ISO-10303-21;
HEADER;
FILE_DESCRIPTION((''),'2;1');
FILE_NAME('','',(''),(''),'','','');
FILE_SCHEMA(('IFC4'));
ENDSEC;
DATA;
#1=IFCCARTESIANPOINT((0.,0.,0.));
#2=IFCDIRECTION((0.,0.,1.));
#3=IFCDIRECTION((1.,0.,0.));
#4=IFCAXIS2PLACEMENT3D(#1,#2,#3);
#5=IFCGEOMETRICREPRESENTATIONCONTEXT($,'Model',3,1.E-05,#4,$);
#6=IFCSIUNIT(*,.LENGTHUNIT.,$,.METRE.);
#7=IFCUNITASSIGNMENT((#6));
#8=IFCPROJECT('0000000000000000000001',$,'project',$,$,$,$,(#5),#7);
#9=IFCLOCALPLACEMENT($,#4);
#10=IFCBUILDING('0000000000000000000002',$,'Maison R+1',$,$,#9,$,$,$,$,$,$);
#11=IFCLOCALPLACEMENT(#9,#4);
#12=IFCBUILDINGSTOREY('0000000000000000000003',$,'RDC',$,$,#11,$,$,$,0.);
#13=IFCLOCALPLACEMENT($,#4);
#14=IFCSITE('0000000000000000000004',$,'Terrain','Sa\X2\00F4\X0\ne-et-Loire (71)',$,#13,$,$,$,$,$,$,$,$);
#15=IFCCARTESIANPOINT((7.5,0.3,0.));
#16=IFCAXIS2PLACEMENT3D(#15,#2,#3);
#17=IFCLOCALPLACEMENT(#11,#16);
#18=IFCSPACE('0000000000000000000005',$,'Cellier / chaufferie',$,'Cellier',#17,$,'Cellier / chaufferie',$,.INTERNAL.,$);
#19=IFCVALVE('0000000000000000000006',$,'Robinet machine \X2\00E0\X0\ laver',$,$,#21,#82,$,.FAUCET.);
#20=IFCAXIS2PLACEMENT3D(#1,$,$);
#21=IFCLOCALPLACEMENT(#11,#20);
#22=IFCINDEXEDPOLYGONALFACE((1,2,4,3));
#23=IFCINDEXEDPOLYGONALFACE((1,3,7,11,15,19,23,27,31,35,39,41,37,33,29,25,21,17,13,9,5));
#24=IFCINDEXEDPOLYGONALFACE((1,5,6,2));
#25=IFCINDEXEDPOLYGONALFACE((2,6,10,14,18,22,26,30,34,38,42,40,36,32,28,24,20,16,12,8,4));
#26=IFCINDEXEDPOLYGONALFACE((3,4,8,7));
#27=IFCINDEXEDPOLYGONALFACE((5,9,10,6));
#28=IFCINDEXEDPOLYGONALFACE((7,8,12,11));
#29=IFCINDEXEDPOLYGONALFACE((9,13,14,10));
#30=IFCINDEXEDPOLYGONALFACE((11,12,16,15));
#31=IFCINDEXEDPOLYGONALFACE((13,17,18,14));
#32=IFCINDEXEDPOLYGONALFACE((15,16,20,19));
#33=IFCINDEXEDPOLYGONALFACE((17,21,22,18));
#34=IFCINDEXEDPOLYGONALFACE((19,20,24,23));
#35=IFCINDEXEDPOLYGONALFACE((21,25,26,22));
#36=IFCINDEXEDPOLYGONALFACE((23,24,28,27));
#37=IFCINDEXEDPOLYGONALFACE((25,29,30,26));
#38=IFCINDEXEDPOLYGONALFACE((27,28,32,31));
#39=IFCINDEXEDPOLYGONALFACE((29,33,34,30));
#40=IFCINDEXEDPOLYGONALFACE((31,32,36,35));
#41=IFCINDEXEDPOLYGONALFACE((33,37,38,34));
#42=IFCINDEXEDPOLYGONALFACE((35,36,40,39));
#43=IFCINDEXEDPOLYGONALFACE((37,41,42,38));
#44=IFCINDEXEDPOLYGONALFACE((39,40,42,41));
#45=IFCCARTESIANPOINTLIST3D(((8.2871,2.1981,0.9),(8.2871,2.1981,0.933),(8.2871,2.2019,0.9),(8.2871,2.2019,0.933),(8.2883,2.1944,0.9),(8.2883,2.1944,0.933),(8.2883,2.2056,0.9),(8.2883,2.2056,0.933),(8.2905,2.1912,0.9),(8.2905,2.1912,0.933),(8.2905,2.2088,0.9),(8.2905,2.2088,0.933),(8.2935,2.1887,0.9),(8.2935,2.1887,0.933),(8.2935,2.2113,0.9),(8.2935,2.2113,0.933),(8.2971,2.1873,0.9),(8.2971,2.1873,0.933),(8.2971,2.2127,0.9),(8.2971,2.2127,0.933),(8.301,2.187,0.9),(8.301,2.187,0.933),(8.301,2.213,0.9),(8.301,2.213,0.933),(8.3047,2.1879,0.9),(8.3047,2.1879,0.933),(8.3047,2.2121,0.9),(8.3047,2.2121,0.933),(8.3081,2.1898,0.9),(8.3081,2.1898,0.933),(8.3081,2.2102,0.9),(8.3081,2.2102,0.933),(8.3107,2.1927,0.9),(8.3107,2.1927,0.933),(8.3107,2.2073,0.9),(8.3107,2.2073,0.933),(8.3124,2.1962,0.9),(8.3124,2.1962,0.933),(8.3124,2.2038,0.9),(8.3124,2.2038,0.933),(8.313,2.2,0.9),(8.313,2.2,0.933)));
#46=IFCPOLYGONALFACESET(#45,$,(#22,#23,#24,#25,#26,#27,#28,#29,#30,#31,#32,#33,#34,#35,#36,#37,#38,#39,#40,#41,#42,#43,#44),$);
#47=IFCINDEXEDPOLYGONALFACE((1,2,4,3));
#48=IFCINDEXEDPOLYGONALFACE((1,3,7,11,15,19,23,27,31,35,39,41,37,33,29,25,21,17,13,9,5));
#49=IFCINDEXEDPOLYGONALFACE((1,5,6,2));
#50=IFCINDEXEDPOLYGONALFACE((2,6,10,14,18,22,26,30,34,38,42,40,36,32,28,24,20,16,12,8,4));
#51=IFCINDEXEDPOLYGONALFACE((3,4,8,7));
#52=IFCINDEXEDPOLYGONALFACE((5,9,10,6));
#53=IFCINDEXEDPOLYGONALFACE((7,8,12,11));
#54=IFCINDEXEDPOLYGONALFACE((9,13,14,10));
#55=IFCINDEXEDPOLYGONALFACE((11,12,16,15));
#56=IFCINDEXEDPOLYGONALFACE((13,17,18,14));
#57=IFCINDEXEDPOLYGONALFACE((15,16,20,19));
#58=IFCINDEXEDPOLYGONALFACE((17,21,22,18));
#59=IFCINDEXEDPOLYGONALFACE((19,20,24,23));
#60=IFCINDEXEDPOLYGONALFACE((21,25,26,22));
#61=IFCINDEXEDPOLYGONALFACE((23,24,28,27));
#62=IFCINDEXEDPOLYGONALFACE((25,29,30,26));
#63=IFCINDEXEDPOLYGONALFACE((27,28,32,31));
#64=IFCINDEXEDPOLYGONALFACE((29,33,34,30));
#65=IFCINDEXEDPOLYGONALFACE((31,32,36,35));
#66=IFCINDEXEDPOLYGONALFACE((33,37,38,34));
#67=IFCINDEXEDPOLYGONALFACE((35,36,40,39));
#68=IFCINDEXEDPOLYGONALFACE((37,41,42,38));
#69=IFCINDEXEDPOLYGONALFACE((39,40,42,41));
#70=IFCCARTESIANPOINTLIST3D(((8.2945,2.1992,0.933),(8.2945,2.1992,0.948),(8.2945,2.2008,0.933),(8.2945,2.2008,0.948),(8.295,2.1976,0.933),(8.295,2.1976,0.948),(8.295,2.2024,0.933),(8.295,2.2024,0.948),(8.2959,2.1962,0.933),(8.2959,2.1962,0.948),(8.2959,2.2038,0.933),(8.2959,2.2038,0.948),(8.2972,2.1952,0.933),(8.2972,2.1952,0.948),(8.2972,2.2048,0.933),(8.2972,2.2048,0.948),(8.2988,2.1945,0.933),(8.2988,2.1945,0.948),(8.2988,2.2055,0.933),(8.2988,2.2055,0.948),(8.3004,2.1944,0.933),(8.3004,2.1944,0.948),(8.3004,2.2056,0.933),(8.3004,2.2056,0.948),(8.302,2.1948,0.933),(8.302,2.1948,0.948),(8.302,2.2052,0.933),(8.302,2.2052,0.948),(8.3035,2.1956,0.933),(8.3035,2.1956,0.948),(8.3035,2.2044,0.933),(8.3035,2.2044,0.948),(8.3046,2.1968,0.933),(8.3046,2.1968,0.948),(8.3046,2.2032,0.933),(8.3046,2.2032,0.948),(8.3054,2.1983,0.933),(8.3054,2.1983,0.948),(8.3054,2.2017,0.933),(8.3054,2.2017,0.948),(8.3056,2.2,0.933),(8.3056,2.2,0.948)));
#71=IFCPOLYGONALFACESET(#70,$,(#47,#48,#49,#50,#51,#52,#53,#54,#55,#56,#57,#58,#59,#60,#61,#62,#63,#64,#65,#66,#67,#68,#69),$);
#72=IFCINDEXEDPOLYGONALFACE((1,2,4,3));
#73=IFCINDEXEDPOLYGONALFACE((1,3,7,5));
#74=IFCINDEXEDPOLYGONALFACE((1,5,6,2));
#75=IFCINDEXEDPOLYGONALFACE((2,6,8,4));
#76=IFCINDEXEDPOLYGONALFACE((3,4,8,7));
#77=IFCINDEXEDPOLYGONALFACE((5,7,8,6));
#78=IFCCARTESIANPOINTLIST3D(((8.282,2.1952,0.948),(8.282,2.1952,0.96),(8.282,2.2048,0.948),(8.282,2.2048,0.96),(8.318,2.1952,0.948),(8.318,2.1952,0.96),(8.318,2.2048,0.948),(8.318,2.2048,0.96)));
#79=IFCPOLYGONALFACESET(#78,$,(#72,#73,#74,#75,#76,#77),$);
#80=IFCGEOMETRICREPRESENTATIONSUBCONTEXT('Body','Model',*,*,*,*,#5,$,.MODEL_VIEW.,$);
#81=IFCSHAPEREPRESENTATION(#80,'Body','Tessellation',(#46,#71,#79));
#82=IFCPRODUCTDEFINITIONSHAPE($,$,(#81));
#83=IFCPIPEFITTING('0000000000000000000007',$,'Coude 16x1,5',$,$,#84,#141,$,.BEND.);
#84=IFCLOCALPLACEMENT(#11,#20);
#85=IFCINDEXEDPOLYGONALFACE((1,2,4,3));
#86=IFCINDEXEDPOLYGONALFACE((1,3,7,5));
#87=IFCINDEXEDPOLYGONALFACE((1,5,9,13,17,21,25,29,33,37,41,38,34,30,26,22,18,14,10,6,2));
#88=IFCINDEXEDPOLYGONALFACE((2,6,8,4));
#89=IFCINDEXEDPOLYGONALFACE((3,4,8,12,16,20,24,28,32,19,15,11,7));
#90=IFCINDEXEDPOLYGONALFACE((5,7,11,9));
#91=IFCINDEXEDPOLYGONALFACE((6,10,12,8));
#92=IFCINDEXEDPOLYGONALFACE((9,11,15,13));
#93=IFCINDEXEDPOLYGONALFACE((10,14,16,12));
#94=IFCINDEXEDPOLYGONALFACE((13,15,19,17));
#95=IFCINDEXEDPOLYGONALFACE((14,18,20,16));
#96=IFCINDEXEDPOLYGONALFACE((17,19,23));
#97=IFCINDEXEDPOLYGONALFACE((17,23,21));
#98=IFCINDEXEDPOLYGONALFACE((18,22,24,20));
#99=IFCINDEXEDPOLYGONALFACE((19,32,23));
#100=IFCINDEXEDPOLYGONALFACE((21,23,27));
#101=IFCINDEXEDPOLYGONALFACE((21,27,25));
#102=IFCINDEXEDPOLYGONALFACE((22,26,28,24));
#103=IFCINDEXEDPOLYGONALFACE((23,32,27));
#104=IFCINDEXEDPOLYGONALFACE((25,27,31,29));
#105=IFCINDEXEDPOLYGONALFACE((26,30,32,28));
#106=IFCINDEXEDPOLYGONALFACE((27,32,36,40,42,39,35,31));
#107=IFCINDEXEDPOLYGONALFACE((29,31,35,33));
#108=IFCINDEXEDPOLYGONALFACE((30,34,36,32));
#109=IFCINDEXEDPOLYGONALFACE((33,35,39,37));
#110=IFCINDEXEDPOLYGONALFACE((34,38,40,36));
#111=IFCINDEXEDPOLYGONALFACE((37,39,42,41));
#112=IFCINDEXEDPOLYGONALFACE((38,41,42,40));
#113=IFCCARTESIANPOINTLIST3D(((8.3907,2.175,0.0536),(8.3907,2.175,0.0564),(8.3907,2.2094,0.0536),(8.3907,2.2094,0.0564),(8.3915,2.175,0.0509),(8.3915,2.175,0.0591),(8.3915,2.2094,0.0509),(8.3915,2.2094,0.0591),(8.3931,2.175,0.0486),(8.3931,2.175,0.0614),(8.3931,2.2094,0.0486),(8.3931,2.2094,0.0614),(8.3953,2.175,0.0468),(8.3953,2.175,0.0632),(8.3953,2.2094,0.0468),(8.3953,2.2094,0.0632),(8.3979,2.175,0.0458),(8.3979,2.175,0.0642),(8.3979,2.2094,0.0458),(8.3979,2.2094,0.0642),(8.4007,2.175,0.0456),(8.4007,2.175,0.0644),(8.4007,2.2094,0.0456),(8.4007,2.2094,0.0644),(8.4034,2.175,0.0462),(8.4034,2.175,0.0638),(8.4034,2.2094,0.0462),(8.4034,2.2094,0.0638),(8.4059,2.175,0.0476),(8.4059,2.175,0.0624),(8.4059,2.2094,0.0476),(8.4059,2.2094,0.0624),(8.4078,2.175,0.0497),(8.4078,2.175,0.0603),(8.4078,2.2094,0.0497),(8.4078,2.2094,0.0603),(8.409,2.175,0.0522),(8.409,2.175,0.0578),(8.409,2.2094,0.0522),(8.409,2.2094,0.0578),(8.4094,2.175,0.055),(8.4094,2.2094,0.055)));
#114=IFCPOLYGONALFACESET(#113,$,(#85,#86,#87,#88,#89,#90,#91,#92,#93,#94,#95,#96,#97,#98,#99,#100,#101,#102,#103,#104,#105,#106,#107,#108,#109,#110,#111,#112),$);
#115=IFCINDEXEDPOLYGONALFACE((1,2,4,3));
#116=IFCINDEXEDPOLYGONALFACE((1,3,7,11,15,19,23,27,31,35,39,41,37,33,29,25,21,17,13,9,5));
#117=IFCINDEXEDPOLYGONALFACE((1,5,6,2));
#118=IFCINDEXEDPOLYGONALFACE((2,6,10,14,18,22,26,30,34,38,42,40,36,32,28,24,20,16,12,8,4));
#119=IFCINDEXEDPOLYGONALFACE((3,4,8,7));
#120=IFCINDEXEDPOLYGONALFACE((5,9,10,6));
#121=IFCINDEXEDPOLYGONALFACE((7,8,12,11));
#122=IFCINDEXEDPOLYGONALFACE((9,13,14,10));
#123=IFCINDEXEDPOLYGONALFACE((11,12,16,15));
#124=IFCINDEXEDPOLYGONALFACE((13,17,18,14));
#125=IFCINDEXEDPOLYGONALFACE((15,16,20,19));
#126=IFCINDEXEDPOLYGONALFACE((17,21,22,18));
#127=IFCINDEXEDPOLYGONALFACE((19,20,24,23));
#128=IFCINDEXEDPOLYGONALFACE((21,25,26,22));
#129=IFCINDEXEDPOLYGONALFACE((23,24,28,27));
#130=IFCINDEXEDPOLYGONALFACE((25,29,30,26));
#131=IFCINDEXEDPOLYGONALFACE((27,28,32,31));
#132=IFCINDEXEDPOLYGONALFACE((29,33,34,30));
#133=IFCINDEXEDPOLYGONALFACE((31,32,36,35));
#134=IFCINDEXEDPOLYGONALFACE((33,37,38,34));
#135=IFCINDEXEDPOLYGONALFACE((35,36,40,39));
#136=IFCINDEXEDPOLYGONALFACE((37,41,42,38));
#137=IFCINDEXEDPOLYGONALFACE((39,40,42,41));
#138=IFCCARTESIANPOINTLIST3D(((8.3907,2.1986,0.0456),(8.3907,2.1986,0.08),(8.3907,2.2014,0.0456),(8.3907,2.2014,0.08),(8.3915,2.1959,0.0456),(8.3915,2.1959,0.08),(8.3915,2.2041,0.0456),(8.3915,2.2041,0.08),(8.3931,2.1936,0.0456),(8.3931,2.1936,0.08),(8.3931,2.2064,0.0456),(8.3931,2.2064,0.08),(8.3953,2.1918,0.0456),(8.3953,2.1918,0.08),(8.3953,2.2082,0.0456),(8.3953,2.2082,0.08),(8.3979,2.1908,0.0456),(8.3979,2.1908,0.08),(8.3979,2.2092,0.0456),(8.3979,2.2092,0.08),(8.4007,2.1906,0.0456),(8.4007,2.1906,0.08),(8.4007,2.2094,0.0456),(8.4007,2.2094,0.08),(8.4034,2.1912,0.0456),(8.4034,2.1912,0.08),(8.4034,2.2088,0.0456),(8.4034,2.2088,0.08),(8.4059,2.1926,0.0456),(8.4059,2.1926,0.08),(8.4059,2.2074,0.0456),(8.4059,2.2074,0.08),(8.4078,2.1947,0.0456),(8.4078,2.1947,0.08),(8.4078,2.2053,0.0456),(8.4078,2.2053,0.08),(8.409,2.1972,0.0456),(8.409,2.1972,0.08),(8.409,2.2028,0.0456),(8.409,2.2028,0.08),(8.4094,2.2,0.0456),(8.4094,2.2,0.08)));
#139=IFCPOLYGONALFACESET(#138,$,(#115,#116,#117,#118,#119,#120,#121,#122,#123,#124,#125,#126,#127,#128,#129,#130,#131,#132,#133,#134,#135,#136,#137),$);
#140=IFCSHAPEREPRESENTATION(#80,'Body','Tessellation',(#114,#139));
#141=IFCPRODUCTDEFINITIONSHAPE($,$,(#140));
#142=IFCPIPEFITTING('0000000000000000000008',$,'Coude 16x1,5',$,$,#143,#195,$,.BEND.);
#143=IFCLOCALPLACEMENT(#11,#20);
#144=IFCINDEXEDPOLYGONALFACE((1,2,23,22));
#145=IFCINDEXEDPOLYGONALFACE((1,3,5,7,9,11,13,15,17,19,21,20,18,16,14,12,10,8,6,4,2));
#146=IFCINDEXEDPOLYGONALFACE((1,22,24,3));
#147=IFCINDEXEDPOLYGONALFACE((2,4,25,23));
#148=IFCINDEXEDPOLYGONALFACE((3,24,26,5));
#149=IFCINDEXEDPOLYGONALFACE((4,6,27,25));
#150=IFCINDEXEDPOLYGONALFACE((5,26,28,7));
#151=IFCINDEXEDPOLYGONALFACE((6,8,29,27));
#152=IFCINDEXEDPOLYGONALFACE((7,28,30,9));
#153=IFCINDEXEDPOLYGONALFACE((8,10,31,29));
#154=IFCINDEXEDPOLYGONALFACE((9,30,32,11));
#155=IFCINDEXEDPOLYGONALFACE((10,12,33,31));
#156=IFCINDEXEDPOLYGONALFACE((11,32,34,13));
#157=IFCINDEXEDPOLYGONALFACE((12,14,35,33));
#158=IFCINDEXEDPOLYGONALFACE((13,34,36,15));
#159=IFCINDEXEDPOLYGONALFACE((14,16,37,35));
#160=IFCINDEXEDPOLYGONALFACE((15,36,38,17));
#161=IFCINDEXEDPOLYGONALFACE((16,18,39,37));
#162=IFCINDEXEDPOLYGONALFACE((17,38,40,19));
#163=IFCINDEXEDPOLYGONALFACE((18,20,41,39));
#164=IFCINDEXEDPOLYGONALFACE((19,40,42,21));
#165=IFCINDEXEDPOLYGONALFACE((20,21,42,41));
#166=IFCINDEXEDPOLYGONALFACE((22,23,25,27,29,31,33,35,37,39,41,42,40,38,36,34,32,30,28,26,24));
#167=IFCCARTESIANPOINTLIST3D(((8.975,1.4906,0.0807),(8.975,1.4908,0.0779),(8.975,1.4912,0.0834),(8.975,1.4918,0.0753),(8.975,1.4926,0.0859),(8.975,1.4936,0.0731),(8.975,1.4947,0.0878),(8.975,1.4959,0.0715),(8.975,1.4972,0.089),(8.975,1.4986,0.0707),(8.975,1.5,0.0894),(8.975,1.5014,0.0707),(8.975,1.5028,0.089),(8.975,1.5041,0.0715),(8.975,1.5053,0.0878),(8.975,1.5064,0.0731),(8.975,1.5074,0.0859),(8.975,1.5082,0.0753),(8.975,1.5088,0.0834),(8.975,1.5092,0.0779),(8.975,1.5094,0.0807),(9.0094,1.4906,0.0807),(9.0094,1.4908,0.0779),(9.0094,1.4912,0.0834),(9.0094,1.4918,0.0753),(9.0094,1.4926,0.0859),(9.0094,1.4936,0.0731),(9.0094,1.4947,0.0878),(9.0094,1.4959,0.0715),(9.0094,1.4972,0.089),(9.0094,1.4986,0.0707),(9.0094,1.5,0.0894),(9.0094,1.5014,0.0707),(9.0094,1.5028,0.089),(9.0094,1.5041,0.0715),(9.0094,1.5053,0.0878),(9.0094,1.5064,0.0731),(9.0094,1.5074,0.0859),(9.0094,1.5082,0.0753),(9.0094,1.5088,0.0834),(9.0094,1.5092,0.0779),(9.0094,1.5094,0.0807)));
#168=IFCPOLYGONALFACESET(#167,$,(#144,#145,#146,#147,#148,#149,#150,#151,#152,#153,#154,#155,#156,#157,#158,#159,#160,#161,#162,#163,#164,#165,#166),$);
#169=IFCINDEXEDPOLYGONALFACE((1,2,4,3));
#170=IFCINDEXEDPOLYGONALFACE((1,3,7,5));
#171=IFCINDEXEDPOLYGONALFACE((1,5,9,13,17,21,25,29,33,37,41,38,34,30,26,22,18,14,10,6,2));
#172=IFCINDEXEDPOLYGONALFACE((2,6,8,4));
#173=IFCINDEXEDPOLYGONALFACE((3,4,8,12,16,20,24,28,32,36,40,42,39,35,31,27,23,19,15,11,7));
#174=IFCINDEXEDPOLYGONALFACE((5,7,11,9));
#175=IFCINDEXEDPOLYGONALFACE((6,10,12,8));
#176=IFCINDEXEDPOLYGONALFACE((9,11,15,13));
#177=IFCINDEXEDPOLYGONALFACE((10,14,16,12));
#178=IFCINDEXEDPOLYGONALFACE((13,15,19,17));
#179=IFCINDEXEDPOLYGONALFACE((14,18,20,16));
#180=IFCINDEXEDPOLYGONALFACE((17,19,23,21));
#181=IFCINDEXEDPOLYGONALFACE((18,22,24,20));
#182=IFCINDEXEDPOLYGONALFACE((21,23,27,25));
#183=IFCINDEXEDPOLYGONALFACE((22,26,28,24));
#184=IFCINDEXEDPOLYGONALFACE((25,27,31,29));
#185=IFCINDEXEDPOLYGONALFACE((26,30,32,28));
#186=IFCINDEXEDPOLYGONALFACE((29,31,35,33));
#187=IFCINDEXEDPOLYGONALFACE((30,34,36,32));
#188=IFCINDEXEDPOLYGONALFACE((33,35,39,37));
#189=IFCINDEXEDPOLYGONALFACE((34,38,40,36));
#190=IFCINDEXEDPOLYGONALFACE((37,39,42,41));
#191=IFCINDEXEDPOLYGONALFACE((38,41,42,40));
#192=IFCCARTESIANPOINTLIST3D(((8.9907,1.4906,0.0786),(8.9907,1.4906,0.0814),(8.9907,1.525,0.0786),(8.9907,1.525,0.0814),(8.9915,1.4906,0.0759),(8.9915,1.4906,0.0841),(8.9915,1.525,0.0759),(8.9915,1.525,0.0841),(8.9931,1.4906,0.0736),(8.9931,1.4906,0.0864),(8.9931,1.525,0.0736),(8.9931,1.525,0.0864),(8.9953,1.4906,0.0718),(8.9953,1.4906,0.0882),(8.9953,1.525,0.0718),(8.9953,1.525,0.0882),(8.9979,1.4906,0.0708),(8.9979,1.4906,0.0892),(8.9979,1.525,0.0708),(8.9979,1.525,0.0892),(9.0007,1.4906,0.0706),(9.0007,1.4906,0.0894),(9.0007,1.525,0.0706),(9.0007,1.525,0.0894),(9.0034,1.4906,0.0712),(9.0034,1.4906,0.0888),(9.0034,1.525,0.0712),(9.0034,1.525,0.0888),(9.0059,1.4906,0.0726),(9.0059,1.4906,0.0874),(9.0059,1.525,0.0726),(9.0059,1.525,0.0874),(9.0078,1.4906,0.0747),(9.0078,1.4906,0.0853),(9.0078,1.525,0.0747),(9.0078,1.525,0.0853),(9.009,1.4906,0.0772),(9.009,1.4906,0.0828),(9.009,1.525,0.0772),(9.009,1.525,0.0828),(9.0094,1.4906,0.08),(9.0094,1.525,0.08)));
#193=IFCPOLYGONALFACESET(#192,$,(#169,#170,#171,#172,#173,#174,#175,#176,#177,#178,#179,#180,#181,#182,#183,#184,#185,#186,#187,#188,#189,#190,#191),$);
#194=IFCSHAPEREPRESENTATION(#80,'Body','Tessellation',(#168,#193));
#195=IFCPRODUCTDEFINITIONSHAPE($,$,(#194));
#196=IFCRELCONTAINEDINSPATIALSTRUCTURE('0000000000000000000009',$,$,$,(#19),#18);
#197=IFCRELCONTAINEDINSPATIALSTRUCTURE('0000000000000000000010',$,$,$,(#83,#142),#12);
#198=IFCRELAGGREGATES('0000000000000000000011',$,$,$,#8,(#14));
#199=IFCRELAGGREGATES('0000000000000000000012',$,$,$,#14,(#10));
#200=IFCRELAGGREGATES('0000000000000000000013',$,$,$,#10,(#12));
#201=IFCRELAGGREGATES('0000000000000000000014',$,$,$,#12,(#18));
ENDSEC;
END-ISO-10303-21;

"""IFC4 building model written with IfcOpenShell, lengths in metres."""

from ifc_helpers import new_model, si_unit, frame, frame_2d, origin_with_axes, place, context, subcontext, project, spatial, rectangle, circle, extrude, element, save


model = new_model("IFC4")

# Units and contexts
model_context = context("Model", 3, precision=1e-05, world=origin_with_axes())
body_context = subcontext(model_context, "Body", "Model", "MODEL_VIEW")
ifc_project = project(units=[si_unit("LENGTHUNIT", "METRE")], contexts=[model_context])

# Site, building, storey
site_placement = place(None, origin_with_axes())
site = spatial("IfcSite", under=ifc_project, at=site_placement, Name="Terrain", Description="Saône-et-Loire (71)")
building_placement = place(None, origin_with_axes())
building = spatial("IfcBuilding", under=site, at=building_placement, Name="Maison R+1")
storey_placement = place(building_placement, origin_with_axes())
storey = spatial("IfcBuildingStorey", under=building, at=storey_placement, Name="RDC", Elevation=0.0)

# Shared definitions
space_1_placement = place(storey_placement, frame((7.5, 0.3, 0.0), z_axis=(0.0, 0.0, 1.0), x_axis=(1.0, 0.0, 0.0)))
space_1 = spatial("IfcSpace", under=storey, at=space_1_placement, Name="Cellier / chaufferie", ObjectType="Cellier", LongName="Cellier / chaufferie", PredefinedType="INTERNAL")

# Valve
valve_placement = place(space_1_placement, frame((0.8, 1.9, 0.9), z_axis=(0.0, 0.0, 1.0), x_axis=(1.0, 0.0, 0.0)))
element("IfcValve", 1, at=valve_placement, inside=space_1, Name="Robinet machine à laver", PredefinedType="FAUCET", context=body_context, shape_type="SweptSolid", body=[
    extrude(circle(Radius=0.013), origin_with_axes(), (0.0, 0.0, 1.0), 0.033),
    extrude(circle(Radius=0.0056), frame((0.0, 0.0, 0.033), z_axis=(0.0, 0.0, 1.0), x_axis=(1.0, 0.0, 0.0)), (0.0, 0.0, 1.0), 0.015),
    extrude(rectangle(XDim=0.036, YDim=0.0096, at=frame_2d((0.018, 0.0048))), frame((-0.018, -0.0048, 0.048), z_axis=(0.0, 0.0, 1.0), x_axis=(1.0, 0.0, 0.0)), (0.0, 0.0, 1.0), 0.012),
])

# Pipe fittings
pipe_fitting_1_placement = place(storey_placement, frame((8.4, 2.2, 0.055), z_axis=(0.0, 0.0, 1.0), x_axis=(1.0, 0.0, 0.0)))
element("IfcPipeFitting", 2, at=pipe_fitting_1_placement, inside=storey, Name="Coude 16x1,5", PredefinedType="BEND", context=body_context, shape_type="SweptSolid", body=[
    extrude(circle(Radius=0.0094), frame((0.0, 0.0094, 0.0), z_axis=(0.0, -1.0, 0.0), x_axis=(1.0, 0.0, 0.0)), (0.0, 0.0, 1.0), 0.0344),
    extrude(circle(Radius=0.0094), frame((0.0, 0.0, -0.0094), z_axis=(0.0, 0.0, 1.0), x_axis=(1.0, 0.0, 0.0)), (0.0, 0.0, 1.0), 0.0344),
])
pipe_fitting_2_placement = place(storey_placement, frame((9.0, 1.5, 0.08), z_axis=(0.0, 0.0, 1.0), x_axis=(1.0, 0.0, 0.0)))
element("IfcPipeFitting", 3, at=pipe_fitting_2_placement, inside=storey, Name="Coude 16x1,5", PredefinedType="BEND", context=body_context, shape_type="SweptSolid", body=[
    extrude(circle(Radius=0.0094), frame((0.0094, 0.0, 0.0), z_axis=(-1.0, 0.0, 0.0), x_axis=(0.0, 0.0, 1.0)), (0.0, 0.0, 1.0), 0.0344),
    extrude(circle(Radius=0.0094), frame((0.0, -0.0094, 0.0), z_axis=(0.0, 1.0, 0.0), x_axis=(1.0, 0.0, 0.0)), (0.0, 0.0, 1.0), 0.0344),
])

save(model, "model.ifc")
